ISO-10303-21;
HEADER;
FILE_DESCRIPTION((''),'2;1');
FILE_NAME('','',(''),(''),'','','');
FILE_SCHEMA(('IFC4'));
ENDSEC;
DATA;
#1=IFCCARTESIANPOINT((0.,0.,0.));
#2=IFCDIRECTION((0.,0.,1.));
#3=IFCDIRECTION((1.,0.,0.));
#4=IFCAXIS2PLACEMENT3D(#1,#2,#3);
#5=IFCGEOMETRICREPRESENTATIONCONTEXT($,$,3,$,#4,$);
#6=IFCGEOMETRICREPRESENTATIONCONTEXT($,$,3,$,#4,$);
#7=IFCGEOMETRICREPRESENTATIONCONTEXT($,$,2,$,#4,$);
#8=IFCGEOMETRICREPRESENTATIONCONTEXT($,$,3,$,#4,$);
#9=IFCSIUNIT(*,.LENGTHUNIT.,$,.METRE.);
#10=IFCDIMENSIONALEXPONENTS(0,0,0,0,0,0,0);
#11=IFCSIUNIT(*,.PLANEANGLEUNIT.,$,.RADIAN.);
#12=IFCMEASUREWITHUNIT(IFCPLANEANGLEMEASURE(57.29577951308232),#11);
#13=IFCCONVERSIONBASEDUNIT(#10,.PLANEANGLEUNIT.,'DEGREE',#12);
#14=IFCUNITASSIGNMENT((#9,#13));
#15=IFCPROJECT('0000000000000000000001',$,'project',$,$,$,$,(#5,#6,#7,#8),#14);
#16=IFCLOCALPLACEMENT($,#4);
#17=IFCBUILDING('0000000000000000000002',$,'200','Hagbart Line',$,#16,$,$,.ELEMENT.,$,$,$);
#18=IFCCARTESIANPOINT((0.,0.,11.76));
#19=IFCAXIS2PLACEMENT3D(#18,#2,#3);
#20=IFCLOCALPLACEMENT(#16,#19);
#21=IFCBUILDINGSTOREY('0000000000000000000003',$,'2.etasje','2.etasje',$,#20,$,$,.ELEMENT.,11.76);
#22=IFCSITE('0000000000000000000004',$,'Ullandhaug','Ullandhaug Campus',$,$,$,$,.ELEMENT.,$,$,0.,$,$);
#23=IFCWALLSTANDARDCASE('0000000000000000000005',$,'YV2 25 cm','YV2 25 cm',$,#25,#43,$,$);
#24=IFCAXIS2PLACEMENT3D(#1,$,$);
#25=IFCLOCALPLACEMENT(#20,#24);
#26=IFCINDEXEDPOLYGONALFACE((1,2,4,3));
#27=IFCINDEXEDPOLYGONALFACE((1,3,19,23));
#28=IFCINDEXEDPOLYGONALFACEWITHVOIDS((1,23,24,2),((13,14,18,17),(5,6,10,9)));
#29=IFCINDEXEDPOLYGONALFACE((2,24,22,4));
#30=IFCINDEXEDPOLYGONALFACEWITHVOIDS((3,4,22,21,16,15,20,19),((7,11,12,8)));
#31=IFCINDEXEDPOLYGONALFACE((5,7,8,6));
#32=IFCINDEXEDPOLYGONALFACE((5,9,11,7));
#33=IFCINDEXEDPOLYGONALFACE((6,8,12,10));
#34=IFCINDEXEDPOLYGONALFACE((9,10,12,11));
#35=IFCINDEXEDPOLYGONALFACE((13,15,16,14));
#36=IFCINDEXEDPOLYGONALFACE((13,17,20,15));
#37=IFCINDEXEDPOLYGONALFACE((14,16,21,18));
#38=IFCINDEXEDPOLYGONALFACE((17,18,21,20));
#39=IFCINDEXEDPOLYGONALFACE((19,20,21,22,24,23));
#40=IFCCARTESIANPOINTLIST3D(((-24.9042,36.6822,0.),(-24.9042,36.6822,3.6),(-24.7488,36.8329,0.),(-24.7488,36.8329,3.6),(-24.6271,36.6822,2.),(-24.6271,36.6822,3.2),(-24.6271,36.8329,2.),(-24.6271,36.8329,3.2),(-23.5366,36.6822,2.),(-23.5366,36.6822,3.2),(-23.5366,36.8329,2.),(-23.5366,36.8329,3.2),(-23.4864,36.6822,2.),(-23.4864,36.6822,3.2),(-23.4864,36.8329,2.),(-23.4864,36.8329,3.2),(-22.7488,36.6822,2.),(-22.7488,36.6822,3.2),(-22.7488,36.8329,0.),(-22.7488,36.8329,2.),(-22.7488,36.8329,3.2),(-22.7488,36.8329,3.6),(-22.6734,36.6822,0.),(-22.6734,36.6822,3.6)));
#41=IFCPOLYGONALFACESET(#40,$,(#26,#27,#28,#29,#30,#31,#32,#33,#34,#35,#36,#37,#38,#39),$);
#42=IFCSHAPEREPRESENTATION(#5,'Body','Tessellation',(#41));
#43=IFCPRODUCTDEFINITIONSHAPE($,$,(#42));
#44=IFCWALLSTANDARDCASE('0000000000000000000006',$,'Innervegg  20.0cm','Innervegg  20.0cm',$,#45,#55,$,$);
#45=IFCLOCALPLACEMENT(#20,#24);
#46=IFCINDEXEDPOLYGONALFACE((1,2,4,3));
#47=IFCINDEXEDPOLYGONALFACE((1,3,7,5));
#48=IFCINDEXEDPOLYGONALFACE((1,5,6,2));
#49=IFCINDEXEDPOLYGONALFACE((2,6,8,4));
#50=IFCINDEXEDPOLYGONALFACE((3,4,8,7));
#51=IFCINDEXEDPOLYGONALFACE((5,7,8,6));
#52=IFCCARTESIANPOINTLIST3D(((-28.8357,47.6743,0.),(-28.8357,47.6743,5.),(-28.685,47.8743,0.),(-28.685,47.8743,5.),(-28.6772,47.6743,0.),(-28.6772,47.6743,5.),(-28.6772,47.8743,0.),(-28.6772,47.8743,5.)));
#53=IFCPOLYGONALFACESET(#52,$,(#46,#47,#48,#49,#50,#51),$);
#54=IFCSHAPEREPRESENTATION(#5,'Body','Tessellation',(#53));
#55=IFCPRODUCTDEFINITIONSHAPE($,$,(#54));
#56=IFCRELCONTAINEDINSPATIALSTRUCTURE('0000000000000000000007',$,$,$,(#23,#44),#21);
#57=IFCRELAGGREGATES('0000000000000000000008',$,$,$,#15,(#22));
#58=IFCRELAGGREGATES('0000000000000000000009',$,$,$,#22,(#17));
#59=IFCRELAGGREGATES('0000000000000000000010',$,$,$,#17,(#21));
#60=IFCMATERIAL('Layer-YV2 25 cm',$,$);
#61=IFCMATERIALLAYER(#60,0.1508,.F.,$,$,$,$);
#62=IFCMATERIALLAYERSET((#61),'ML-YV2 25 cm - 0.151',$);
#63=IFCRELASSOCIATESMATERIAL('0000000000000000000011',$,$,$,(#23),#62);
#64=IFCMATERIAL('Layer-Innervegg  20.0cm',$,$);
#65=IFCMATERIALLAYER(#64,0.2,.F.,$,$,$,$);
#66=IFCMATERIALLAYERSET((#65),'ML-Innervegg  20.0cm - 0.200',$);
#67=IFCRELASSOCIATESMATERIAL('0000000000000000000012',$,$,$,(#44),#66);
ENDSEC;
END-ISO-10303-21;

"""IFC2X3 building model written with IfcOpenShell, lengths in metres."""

from ifc_helpers import new_model, entity, si_unit, converted_unit, frame, origin_with_axes, place, context, project, spatial, polyline, outline, extrude, material, layer, layer_set, layer_usage, element, save


model = new_model("IFC2X3")

# Units and contexts
context_of_model_1 = context(None, 3, world=origin_with_axes())
context_of_model_2 = context(None, 3, world=origin_with_axes())
context_of_model_3 = context(None, 2, world=origin_with_axes())
context_of_model_4 = context(None, 3, world=origin_with_axes())
ifc_project = project(units=[si_unit("LENGTHUNIT", "METRE"), converted_unit("PLANEANGLEUNIT", "DEGREE", entity("IfcPlaneAngleMeasure", 57.29577951308232), si_unit("PLANEANGLEUNIT", "RADIAN"), dimensions=[0, 0, 0, 0, 0, 0, 0])], contexts=[context_of_model_1, context_of_model_2, context_of_model_3, context_of_model_4])

# Site, building, storey
site = spatial("IfcSite", under=ifc_project, Name="Ullandhaug", Description="Ullandhaug Campus", CompositionType="ELEMENT", RefElevation=0.0)
building_placement = place(None, origin_with_axes())
building = spatial("IfcBuilding", under=site, at=building_placement, Name="200", Description="Hagbart Line", CompositionType="ELEMENT")
storey_placement = place(building_placement, frame((0.0, 0.0, 11.76), z_axis=(0.0, 0.0, 1.0), x_axis=(1.0, 0.0, 0.0)))
storey = spatial("IfcBuildingStorey", under=building, at=storey_placement, Name="2.etasje", Description="2.etasje", CompositionType="ELEMENT", Elevation=11.76)

# Wall, openings
ifc_material_1 = material(Name="Layer-YV2 25 cm")
ifc_layer_1 = layer(ifc_material_1, 0.1508, ventilated=False)
ifc_layer_set_1 = layer_set([ifc_layer_1], Name="ML-YV2 25 cm - 0.151")
ifc_layer_usage_1 = layer_usage(ifc_layer_set_1, "AXIS2", "POSITIVE", 0.0)
wall_1_placement = place(storey_placement, frame((-24.9042, 36.6822, 0.0), z_axis=(0.0, 0.0, 1.0), x_axis=(1.0, 0.0, 0.0)))
wall_1 = element("IfcWallStandardCase", 1, at=wall_1_placement, inside=storey, material=ifc_layer_usage_1, Name="YV2 25 cm", Description="YV2 25 cm", context=context_of_model_1, shape_type="SweptSolid", body=[
    extrude(outline(polyline([(0.0, 0.0), (2.2307, 0.0), (2.1553, 0.1507), (0.1553, 0.1507), (0.0, 0.0)])), origin_with_axes(), (0.0, 0.0, 1.0), 3.6),
])
opening_1_placement = place(wall_1_placement, frame((0.2771, 0.1507, 2.0), z_axis=(0.0, 0.0, 1.0), x_axis=(1.0, 0.0, 0.0)))
element("IfcOpeningElement", 2, at=opening_1_placement, cuts=wall_1, context=context_of_model_1, shape_type="SweptSolid", body=[
    extrude(outline(polyline([(0.0, 0.0), (1.2, 0.0), (1.2, 1.0904), (0.0, 1.0904), (0.0, 0.0)])), frame((0.0, 0.0, 0.0), z_axis=(0.0, 1.0, 0.0), x_axis=(0.0, 0.0, 1.0)), (0.0, 0.0, -1.0), 0.1507),
])
opening_2_placement = place(wall_1_placement, frame((1.4178, 0.1507, 2.0), z_axis=(0.0, 0.0, 1.0), x_axis=(1.0, 0.0, 0.0)))
element("IfcOpeningElement", 3, at=opening_2_placement, cuts=wall_1, context=context_of_model_1, shape_type="SweptSolid", body=[
    extrude(outline(polyline([(0.0, 0.0), (1.2, 0.0), (1.2, 0.7376), (0.0, 0.7376), (0.0, 0.0)])), frame((0.0, 0.0, 0.0), z_axis=(0.0, 1.0, 0.0), x_axis=(0.0, 0.0, 1.0)), (0.0, 0.0, -1.0), 0.1507),
])

# Wall
ifc_material_2 = material(Name="Layer-Innervegg  20.0cm")
ifc_layer_2 = layer(ifc_material_2, 0.2, ventilated=False)
ifc_layer_set_2 = layer_set([ifc_layer_2], Name="ML-Innervegg  20.0cm - 0.200")
ifc_layer_usage_2 = layer_usage(ifc_layer_set_2, "AXIS2", "POSITIVE", 0.0)
wall_2_placement = place(storey_placement, frame((-28.8357, 47.6743, 0.0), z_axis=(0.0, 0.0, 1.0), x_axis=(1.0, 0.0, 0.0)))
element("IfcWallStandardCase", 4, at=wall_2_placement, inside=storey, material=ifc_layer_usage_2, Name="Innervegg  20.0cm", Description="Innervegg  20.0cm", context=context_of_model_1, shape_type="SweptSolid", body=[
    extrude(outline(polyline([(0.0, 0.0), (0.1585, 0.0), (0.1585, 0.2), (0.1508, 0.2), (0.0, 0.0)])), origin_with_axes(), (0.0, 0.0, 1.0), 5.0),
])

save(model, "model.ifc")
